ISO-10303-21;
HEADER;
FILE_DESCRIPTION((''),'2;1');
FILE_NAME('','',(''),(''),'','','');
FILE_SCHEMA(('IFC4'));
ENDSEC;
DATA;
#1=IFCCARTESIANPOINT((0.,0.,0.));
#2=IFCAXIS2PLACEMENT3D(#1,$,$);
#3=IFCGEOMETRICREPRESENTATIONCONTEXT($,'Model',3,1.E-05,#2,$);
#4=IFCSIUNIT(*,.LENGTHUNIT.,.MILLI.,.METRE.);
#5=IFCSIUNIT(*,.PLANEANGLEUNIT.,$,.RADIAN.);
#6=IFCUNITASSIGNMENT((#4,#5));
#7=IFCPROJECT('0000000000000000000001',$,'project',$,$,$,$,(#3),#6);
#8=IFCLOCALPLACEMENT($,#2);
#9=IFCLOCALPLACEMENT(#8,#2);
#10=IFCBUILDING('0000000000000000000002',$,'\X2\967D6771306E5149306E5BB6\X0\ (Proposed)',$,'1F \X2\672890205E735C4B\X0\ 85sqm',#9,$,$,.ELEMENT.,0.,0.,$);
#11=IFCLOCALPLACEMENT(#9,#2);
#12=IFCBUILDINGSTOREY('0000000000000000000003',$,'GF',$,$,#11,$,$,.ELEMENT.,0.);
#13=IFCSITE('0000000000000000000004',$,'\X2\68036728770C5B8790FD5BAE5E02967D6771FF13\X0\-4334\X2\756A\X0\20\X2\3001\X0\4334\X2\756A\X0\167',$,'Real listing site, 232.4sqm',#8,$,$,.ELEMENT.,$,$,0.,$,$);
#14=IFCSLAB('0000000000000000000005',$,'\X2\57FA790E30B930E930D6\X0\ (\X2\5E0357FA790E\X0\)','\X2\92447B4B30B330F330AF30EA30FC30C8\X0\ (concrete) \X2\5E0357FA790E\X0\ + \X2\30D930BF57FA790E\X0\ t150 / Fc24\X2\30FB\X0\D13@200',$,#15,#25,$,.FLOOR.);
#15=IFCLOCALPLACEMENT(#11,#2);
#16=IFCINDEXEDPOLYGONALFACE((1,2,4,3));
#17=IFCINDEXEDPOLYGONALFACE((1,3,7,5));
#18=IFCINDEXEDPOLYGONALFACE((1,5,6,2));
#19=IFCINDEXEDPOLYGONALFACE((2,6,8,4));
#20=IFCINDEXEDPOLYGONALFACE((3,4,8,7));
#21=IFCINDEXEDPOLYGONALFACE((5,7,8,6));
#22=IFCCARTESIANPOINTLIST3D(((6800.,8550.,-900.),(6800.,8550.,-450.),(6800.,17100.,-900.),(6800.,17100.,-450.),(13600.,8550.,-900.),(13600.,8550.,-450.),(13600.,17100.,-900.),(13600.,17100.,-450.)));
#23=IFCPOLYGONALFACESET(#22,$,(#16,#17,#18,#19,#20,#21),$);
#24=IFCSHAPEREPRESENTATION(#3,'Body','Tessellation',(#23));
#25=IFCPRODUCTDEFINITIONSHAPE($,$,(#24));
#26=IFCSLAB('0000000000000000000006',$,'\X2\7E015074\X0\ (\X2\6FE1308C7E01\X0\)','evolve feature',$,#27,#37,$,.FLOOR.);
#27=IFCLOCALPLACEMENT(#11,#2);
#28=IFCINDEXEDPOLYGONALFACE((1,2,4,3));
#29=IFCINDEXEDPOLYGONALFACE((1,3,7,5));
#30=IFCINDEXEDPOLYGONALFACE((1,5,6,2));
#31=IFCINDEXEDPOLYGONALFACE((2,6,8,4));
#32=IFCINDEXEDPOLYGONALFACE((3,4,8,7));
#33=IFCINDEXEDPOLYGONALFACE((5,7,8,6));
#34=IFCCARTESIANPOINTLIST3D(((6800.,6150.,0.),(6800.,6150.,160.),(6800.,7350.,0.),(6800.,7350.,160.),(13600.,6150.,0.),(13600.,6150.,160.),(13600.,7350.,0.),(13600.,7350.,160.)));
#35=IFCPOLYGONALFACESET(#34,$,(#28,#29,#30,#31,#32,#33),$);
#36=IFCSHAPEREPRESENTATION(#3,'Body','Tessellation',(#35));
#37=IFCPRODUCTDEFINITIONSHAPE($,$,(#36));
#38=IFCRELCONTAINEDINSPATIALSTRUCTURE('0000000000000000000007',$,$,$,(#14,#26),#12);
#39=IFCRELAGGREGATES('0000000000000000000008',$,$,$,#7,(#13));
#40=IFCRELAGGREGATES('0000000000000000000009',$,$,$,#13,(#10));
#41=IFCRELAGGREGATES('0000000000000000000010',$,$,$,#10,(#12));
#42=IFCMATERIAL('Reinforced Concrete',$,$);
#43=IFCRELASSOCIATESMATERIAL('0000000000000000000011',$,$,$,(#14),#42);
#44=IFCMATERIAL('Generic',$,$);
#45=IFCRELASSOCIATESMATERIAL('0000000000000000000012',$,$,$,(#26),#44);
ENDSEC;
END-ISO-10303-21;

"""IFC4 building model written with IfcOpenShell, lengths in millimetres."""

from ifc_helpers import new_model, si_unit, frame, frame_2d, origin, place, context, project, spatial, rectangle, extrude, material, element, save


model = new_model("IFC4")

# Units and contexts
model_context = context("Model", 3, precision=1e-05, world=origin())
ifc_project = project(units=[si_unit("LENGTHUNIT", "METRE", prefix="MILLI"), si_unit("PLANEANGLEUNIT", "RADIAN")], contexts=[model_context])

# Site, building, storey
site_placement = place(None, origin())
site = spatial("IfcSite", under=ifc_project, at=site_placement, Name="栃木県宇都宮市陽東３-4334番20、4334番167", ObjectType="Real listing site, 232.4sqm", CompositionType="ELEMENT", RefElevation=0.0)
building_placement = place(site_placement, origin())
building = spatial("IfcBuilding", under=site, at=building_placement, Name="陽東の光の家 (Proposed)", ObjectType="1F 木造平屋 85sqm", CompositionType="ELEMENT", ElevationOfRefHeight=0.0, ElevationOfTerrain=0.0)
storey_placement = place(building_placement, origin())
storey = spatial("IfcBuildingStorey", under=building, at=storey_placement, Name="GF", CompositionType="ELEMENT", Elevation=0.0)

# Slabs
ifc_material_1 = material(Name="Reinforced Concrete")
slab_1_placement = place(storey_placement, frame((3400.0, 4275.0, -450.0)))
element("IfcSlab", 1, at=slab_1_placement, inside=storey, material=ifc_material_1, Name="基礎スラブ (布基礎)", Description="鉄筋コンクリート (concrete) 布基礎 + ベタ基礎 t150 / Fc24・D13@200", PredefinedType="FLOOR", context=model_context, shape_type="SweptSolid", body=[
    extrude(rectangle(XDim=6800.0, YDim=8550.0, at=frame_2d((3400.0, 4275.0))), frame((3400.0, 4275.0, -450.0)), (0.0, 0.0, 1.0), 450.0),
])
ifc_material_2 = material(Name="Generic")
slab_2_placement = place(storey_placement, frame((3400.0, 3075.0, 0.0)))
element("IfcSlab", 2, at=slab_2_placement, inside=storey, material=ifc_material_2, Name="縁側 (濡れ縁)", Description="evolve feature", PredefinedType="FLOOR", context=model_context, shape_type="SweptSolid", body=[
    extrude(rectangle(XDim=6800.0, YDim=1200.0, at=frame_2d((3400.0, 600.0))), frame((3400.0, 3075.0, 0.0)), (0.0, 0.0, 1.0), 160.0),
])

save(model, "model.ifc")
